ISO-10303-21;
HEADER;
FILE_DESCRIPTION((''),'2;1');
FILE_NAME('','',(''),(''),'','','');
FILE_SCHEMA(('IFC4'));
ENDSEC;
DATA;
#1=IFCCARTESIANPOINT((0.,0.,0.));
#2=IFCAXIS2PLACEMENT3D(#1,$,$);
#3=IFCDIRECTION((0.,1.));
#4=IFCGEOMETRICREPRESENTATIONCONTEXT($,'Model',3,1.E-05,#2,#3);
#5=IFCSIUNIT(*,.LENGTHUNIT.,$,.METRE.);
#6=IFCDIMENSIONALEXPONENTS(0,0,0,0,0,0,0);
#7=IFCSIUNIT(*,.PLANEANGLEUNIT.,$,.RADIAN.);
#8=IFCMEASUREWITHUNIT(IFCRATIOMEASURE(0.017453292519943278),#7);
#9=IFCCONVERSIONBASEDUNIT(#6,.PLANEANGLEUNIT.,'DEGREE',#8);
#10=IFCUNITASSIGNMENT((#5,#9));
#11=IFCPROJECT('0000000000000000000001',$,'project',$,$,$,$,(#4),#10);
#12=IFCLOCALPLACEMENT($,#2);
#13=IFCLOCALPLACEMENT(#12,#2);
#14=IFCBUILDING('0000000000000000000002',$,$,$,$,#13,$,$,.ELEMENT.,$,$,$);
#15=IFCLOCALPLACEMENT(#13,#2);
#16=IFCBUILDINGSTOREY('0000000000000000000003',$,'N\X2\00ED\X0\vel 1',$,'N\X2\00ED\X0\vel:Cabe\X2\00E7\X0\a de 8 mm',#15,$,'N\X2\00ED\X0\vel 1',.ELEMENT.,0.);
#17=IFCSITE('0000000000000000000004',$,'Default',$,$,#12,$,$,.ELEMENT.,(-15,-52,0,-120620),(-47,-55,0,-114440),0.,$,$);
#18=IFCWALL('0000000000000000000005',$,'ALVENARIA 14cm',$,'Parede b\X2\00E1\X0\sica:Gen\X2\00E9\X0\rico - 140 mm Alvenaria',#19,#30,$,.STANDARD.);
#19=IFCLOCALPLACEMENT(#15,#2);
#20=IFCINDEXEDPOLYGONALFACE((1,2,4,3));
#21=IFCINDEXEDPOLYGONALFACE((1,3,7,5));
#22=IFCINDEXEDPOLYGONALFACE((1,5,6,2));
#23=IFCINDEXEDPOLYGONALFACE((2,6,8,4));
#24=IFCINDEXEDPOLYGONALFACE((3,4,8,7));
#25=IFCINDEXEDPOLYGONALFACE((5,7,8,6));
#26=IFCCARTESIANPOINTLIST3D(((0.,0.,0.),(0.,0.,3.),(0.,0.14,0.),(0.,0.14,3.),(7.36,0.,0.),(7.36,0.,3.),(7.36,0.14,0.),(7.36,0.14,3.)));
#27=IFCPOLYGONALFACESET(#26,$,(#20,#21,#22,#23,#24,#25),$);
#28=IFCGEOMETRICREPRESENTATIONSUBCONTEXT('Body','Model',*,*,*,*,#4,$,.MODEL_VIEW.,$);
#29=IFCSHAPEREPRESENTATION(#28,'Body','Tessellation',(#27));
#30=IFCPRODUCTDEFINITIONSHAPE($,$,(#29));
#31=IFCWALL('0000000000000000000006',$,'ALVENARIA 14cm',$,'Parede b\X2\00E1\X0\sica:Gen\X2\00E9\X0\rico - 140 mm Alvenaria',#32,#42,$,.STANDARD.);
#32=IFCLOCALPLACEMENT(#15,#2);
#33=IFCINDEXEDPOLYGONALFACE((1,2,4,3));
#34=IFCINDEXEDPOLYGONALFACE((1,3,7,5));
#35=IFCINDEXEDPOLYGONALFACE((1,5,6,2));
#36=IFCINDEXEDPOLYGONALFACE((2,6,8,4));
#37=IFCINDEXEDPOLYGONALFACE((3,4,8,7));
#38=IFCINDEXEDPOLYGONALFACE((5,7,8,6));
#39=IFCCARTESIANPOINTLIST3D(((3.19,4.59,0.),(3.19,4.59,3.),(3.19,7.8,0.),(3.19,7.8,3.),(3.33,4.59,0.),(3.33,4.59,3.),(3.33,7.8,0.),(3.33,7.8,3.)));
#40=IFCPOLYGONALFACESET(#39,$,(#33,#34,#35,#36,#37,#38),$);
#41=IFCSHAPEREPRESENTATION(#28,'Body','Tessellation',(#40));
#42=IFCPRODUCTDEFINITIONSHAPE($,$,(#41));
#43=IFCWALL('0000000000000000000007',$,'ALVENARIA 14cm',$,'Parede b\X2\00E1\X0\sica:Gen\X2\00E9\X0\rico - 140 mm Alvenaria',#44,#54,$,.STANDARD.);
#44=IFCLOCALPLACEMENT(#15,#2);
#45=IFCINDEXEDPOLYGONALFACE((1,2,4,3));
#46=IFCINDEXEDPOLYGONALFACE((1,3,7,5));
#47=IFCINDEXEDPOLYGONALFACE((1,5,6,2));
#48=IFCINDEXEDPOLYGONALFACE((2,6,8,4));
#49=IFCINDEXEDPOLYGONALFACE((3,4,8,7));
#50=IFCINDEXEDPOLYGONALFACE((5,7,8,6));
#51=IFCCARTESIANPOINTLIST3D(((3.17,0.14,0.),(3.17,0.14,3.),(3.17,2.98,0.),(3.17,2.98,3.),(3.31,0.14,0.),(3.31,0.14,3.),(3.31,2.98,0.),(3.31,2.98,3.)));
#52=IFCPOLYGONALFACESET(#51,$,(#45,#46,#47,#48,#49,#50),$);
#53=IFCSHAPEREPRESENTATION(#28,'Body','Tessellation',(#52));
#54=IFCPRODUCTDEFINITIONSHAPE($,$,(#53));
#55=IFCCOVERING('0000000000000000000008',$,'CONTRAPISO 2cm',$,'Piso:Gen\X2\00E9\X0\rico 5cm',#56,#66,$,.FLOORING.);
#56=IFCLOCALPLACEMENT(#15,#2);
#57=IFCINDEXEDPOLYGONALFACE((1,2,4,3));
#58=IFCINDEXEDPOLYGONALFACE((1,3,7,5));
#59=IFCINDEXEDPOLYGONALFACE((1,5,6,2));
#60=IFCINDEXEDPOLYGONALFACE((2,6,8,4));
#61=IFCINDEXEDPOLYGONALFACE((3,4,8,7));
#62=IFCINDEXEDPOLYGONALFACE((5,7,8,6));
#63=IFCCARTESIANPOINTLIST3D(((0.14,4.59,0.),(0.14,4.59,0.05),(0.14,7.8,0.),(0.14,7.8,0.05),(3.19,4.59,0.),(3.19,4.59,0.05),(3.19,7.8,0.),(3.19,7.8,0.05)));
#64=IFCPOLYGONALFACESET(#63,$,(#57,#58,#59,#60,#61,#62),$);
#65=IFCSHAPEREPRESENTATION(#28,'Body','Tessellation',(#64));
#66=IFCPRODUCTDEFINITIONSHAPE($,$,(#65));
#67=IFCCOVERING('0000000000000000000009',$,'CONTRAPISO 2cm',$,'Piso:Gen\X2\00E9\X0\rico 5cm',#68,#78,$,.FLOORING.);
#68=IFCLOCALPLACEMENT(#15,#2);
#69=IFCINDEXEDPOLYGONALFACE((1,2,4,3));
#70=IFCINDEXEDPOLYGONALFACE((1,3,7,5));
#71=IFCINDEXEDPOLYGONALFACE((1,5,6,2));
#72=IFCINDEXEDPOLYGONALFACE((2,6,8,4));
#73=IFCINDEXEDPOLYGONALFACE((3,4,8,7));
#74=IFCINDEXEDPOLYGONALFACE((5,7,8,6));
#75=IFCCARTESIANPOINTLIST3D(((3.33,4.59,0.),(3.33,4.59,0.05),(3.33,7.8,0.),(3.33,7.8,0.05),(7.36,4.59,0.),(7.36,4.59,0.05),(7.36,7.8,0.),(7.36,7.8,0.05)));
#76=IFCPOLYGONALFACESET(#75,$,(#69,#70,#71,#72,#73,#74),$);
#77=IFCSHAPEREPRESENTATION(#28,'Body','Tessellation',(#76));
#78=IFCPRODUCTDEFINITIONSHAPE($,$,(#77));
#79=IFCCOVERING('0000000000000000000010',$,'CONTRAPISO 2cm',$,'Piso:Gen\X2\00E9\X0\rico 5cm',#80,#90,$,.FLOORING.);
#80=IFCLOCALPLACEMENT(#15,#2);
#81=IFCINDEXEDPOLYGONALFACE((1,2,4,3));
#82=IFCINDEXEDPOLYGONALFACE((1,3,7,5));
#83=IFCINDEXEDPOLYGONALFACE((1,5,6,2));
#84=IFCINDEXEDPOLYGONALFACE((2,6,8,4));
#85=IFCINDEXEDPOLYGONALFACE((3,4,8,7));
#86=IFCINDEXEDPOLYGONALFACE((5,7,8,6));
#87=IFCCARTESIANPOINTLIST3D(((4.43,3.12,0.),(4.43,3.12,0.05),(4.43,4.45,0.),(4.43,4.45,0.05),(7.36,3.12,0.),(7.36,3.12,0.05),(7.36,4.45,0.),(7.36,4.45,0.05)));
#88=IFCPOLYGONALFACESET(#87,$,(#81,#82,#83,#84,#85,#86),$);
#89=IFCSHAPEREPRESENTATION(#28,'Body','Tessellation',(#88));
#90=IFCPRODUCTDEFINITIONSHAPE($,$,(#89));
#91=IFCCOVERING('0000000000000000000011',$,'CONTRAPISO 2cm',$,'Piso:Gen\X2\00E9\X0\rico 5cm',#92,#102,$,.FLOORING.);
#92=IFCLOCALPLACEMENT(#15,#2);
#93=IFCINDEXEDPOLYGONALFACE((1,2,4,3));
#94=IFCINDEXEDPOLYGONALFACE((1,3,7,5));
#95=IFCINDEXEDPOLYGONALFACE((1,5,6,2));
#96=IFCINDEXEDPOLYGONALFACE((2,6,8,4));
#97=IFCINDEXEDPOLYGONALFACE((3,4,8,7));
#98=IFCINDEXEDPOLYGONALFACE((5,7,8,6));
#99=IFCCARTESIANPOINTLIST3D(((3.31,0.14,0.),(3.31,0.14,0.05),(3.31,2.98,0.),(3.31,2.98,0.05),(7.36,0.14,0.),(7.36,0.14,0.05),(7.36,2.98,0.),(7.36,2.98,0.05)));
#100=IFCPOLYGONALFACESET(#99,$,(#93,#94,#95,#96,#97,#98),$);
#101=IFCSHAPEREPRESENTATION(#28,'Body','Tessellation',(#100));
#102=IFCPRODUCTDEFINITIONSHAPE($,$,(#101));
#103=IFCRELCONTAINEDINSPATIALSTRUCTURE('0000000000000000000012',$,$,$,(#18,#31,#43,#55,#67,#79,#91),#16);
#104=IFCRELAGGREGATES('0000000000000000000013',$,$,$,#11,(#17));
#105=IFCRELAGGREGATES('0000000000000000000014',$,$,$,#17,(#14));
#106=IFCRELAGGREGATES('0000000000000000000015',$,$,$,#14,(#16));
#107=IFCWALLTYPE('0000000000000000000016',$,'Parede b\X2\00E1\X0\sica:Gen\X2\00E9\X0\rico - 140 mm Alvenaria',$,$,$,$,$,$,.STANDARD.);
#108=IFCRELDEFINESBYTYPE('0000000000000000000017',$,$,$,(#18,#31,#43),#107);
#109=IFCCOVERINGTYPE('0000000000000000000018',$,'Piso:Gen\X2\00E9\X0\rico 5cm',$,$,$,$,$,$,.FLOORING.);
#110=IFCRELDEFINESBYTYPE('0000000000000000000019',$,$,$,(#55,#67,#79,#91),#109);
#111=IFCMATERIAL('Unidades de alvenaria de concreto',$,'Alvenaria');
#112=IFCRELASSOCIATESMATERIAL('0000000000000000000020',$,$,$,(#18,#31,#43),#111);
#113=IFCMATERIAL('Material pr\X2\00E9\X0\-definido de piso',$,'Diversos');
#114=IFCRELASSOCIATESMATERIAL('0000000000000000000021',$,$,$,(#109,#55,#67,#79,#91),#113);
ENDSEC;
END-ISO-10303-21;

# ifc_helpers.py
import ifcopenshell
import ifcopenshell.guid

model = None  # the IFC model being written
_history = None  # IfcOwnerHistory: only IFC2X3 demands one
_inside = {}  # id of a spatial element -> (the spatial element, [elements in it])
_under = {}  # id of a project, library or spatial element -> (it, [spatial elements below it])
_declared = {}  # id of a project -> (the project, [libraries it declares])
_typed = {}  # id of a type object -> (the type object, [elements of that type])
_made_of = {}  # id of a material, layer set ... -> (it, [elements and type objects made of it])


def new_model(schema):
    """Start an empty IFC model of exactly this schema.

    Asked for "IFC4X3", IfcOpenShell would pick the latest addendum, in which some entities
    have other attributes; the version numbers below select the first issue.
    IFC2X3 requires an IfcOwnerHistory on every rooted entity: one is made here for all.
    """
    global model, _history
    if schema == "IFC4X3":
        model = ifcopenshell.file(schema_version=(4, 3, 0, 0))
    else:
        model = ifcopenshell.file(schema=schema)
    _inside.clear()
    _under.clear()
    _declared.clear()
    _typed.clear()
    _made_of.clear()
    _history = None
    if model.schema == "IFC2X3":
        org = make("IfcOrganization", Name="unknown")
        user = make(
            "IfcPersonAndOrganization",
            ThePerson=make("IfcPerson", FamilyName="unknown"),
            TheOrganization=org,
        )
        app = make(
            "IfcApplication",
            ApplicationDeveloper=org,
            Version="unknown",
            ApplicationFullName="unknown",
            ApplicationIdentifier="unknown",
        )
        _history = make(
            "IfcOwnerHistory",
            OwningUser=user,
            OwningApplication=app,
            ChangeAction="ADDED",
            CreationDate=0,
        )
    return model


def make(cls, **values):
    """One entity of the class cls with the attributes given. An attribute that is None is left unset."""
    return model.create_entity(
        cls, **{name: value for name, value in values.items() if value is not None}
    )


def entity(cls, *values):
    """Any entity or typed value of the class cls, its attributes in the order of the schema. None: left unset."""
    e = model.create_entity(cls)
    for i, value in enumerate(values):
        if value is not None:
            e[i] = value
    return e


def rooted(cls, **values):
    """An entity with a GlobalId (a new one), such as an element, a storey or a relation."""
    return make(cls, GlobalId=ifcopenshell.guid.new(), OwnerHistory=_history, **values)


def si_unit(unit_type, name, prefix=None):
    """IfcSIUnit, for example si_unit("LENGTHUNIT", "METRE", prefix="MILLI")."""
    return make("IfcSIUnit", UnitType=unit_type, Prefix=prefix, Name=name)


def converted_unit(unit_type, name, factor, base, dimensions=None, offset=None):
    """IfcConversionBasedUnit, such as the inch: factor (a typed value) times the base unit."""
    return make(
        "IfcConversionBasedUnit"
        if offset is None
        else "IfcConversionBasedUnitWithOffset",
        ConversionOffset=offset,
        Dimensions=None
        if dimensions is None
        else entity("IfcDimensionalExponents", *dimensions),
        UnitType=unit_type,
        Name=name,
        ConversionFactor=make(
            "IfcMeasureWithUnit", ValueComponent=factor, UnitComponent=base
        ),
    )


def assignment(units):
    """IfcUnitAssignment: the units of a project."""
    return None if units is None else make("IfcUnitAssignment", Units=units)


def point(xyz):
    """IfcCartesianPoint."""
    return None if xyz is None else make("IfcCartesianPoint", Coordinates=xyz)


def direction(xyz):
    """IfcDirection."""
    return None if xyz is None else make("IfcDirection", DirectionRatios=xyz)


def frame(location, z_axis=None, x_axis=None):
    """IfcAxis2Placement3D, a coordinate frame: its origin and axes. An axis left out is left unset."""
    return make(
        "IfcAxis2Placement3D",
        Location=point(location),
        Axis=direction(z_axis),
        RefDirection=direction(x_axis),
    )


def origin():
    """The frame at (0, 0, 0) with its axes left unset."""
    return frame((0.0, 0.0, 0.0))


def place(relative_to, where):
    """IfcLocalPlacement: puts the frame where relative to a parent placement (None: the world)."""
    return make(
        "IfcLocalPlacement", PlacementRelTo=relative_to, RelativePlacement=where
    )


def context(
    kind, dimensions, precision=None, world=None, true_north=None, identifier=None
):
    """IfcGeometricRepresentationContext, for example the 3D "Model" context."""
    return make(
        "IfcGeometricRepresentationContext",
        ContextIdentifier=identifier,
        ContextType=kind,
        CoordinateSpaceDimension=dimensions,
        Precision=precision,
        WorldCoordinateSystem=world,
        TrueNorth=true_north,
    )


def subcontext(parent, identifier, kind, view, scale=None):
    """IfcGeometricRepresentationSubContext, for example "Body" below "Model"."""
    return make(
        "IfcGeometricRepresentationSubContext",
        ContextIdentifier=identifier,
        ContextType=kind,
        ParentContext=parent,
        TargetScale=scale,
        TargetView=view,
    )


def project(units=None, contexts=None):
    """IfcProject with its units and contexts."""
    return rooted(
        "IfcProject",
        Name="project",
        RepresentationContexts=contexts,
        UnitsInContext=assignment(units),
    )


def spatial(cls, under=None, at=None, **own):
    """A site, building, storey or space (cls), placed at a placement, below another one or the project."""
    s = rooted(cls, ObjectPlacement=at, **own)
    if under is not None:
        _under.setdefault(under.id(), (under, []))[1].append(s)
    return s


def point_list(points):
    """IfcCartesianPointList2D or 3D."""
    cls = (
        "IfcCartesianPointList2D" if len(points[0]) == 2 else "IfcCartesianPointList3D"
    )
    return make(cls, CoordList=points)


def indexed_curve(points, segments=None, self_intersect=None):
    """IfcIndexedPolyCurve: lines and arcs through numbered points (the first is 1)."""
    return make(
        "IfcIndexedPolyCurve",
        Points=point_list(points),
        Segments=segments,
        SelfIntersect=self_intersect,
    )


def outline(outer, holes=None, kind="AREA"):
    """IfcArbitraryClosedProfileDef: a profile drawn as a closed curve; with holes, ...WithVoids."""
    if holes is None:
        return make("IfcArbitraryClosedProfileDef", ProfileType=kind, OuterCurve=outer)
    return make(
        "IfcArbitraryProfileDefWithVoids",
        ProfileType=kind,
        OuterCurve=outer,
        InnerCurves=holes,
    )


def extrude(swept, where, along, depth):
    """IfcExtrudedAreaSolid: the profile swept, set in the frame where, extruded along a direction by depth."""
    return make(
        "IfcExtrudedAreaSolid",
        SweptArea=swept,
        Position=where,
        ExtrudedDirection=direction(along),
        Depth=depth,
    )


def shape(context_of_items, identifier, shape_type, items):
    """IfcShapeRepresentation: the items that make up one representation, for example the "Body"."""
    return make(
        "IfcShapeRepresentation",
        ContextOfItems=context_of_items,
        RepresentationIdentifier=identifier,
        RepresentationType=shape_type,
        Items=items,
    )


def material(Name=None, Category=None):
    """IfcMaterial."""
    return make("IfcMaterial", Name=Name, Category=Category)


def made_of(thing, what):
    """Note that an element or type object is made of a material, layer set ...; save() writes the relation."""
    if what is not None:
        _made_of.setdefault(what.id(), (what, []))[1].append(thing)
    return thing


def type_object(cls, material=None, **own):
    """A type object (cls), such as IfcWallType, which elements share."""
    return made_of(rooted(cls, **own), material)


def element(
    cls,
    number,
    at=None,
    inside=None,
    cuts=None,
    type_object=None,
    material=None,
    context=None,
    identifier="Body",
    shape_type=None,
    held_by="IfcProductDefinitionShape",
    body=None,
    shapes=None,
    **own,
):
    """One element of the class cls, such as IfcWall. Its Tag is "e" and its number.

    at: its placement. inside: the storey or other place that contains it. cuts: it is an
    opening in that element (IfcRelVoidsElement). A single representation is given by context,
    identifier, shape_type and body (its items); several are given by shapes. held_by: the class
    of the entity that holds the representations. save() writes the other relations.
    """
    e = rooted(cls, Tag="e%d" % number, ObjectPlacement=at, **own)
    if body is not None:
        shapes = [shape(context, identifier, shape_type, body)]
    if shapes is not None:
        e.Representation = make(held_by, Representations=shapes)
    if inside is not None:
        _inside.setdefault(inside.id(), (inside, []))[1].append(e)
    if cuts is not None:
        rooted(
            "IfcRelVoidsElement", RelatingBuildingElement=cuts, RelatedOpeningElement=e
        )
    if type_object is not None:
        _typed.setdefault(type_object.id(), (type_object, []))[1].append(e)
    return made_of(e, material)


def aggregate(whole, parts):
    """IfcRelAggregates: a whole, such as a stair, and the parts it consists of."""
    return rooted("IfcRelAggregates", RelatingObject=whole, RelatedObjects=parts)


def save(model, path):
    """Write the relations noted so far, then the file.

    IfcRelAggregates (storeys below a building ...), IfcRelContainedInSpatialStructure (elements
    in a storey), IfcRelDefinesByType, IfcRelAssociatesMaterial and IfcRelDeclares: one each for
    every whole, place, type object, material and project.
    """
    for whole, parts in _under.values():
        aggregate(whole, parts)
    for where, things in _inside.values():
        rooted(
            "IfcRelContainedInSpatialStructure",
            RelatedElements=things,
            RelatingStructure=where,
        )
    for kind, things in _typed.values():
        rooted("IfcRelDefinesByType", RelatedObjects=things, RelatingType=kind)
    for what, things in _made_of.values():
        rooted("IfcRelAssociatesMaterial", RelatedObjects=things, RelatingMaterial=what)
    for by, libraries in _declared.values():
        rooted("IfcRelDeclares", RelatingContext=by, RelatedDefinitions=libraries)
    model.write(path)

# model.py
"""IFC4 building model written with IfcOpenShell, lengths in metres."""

from ifc_helpers import new_model, entity, si_unit, converted_unit, direction, frame, origin, place, context, subcontext, project, spatial, indexed_curve, outline, extrude, material, type_object, element, save


model = new_model("IFC4")

# Units and contexts
model_context = context("Model", 3, precision=1e-05, world=origin(), true_north=direction((0.0, 1.0)))
body_context = subcontext(model_context, "Body", "Model", "MODEL_VIEW")
ifc_project = project(units=[si_unit("LENGTHUNIT", "METRE"), converted_unit("PLANEANGLEUNIT", "DEGREE", entity("IfcRatioMeasure", 0.017453292519943278), si_unit("PLANEANGLEUNIT", "RADIAN"), dimensions=[0, 0, 0, 0, 0, 0, 0])], contexts=[model_context])

# Site, building, storey
site_placement = place(None, origin())
site = spatial("IfcSite", under=ifc_project, at=site_placement, Name="Default", CompositionType="ELEMENT", RefLatitude=(-15, -52, 0, -120620), RefLongitude=(-47, -55, 0, -114440), RefElevation=0.0)
building_placement = place(site_placement, origin())
building = spatial("IfcBuilding", under=site, at=building_placement, CompositionType="ELEMENT")
storey_placement = place(building_placement, origin())
storey = spatial("IfcBuildingStorey", under=building, at=storey_placement, Name="Nível 1", ObjectType="Nível:Cabeça de 8 mm", LongName="Nível 1", CompositionType="ELEMENT", Elevation=0.0)

# Walls
ifc_material_1 = material(Name="Unidades de alvenaria de concreto", Category="Alvenaria")
wall_type = type_object("IfcWallType", Name="Parede básica:Genérico - 140 mm Alvenaria", PredefinedType="STANDARD")
wall_1_placement = place(storey_placement, frame((7.36, 0.07, 0.0), z_axis=(0.0, 0.0, 1.0), x_axis=(-1.0, 0.0, 0.0)))
element("IfcWall", 1, at=wall_1_placement, inside=storey, type_object=wall_type, material=ifc_material_1, Name="ALVENARIA 14cm", ObjectType="Parede básica:Genérico - 140 mm Alvenaria", PredefinedType="STANDARD", context=body_context, shape_type="SweptSolid", body=[
    extrude(outline(indexed_curve([(7.36, 0.07), (0.0, 0.07), (0.0, -0.07), (7.36, -0.07), (7.36, 0.07)], self_intersect=False)), origin(), (0.0, 0.0, 1.0), 3.0),
])
wall_2_placement = place(storey_placement, frame((3.26, 4.59, 0.0), z_axis=(0.0, 0.0, 1.0), x_axis=(0.0, 1.0, 0.0)))
element("IfcWall", 2, at=wall_2_placement, inside=storey, type_object=wall_type, material=ifc_material_1, Name="ALVENARIA 14cm", ObjectType="Parede básica:Genérico - 140 mm Alvenaria", PredefinedType="STANDARD", context=body_context, shape_type="SweptSolid", body=[
    extrude(outline(indexed_curve([(3.21, 0.07), (0.0, 0.07), (0.0, -0.07), (3.21, -0.07), (3.21, 0.07)], self_intersect=False)), origin(), (0.0, 0.0, 1.0), 3.0),
])
wall_3_placement = place(storey_placement, frame((3.24, 2.98, 0.0), z_axis=(0.0, 0.0, 1.0), x_axis=(0.0, -1.0, 0.0)))
element("IfcWall", 3, at=wall_3_placement, inside=storey, type_object=wall_type, material=ifc_material_1, Name="ALVENARIA 14cm", ObjectType="Parede básica:Genérico - 140 mm Alvenaria", PredefinedType="STANDARD", context=body_context, shape_type="SweptSolid", body=[
    extrude(outline(indexed_curve([(2.84, 0.07), (0.0, 0.07), (0.0, -0.07), (2.84, -0.07), (2.84, 0.07)], self_intersect=False)), origin(), (0.0, 0.0, 1.0), 3.0),
])

# Coverings
ifc_material_2 = material(Name="Material pré-definido de piso", Category="Diversos")
covering_type = type_object("IfcCoveringType", Name="Piso:Genérico 5cm", PredefinedType="FLOORING", material=ifc_material_2)
covering_1_placement = place(storey_placement, origin())
element("IfcCovering", 4, at=covering_1_placement, inside=storey, type_object=covering_type, material=ifc_material_2, Name="CONTRAPISO 2cm", ObjectType="Piso:Genérico 5cm", PredefinedType="FLOORING", context=body_context, shape_type="SweptSolid", body=[
    extrude(outline(indexed_curve([(-1.605, -1.525), (1.605, -1.525), (1.605, 1.525), (-1.605, 1.525), (-1.605, -1.525)], self_intersect=False)), frame((1.665, 6.195, 0.05), z_axis=(0.0, 0.0, -1.0), x_axis=(0.0, 1.0, 0.0)), (0.0, 0.0, 1.0), 0.05),
])
covering_2_placement = place(storey_placement, origin())
element("IfcCovering", 5, at=covering_2_placement, inside=storey, type_object=covering_type, material=ifc_material_2, Name="CONTRAPISO 2cm", ObjectType="Piso:Genérico 5cm", PredefinedType="FLOORING", context=body_context, shape_type="SweptSolid", body=[
    extrude(outline(indexed_curve([(-1.605, -2.015), (1.605, -2.015), (1.605, 2.015), (-1.605, 2.015), (-1.605, -2.015)], self_intersect=False)), frame((5.345, 6.195, 0.05), z_axis=(0.0, 0.0, -1.0), x_axis=(0.0, 1.0, 0.0)), (0.0, 0.0, 1.0), 0.05),
])
covering_3_placement = place(storey_placement, origin())
element("IfcCovering", 6, at=covering_3_placement, inside=storey, type_object=covering_type, material=ifc_material_2, Name="CONTRAPISO 2cm", ObjectType="Piso:Genérico 5cm", PredefinedType="FLOORING", context=body_context, shape_type="SweptSolid", body=[
    extrude(outline(indexed_curve([(-0.665, -1.465), (0.665, -1.465), (0.665, 1.465), (-0.665, 1.465), (-0.665, -1.465)], self_intersect=False)), frame((5.895, 3.785, 0.05), z_axis=(0.0, 0.0, -1.0), x_axis=(0.0, 1.0, 0.0)), (0.0, 0.0, 1.0), 0.05),
])
covering_4_placement = place(storey_placement, origin())
element("IfcCovering", 7, at=covering_4_placement, inside=storey, type_object=covering_type, material=ifc_material_2, Name="CONTRAPISO 2cm", ObjectType="Piso:Genérico 5cm", PredefinedType="FLOORING", context=body_context, shape_type="SweptSolid", body=[
    extrude(outline(indexed_curve([(-1.42, -2.025), (1.42, -2.025), (1.42, 2.025), (-1.42, 2.025), (-1.42, -2.025)], self_intersect=False)), frame((5.335, 1.56, 0.05), z_axis=(0.0, 0.0, -1.0), x_axis=(0.0, 1.0, 0.0)), (0.0, 0.0, 1.0), 0.05),
])

save(model, "model.ifc")
